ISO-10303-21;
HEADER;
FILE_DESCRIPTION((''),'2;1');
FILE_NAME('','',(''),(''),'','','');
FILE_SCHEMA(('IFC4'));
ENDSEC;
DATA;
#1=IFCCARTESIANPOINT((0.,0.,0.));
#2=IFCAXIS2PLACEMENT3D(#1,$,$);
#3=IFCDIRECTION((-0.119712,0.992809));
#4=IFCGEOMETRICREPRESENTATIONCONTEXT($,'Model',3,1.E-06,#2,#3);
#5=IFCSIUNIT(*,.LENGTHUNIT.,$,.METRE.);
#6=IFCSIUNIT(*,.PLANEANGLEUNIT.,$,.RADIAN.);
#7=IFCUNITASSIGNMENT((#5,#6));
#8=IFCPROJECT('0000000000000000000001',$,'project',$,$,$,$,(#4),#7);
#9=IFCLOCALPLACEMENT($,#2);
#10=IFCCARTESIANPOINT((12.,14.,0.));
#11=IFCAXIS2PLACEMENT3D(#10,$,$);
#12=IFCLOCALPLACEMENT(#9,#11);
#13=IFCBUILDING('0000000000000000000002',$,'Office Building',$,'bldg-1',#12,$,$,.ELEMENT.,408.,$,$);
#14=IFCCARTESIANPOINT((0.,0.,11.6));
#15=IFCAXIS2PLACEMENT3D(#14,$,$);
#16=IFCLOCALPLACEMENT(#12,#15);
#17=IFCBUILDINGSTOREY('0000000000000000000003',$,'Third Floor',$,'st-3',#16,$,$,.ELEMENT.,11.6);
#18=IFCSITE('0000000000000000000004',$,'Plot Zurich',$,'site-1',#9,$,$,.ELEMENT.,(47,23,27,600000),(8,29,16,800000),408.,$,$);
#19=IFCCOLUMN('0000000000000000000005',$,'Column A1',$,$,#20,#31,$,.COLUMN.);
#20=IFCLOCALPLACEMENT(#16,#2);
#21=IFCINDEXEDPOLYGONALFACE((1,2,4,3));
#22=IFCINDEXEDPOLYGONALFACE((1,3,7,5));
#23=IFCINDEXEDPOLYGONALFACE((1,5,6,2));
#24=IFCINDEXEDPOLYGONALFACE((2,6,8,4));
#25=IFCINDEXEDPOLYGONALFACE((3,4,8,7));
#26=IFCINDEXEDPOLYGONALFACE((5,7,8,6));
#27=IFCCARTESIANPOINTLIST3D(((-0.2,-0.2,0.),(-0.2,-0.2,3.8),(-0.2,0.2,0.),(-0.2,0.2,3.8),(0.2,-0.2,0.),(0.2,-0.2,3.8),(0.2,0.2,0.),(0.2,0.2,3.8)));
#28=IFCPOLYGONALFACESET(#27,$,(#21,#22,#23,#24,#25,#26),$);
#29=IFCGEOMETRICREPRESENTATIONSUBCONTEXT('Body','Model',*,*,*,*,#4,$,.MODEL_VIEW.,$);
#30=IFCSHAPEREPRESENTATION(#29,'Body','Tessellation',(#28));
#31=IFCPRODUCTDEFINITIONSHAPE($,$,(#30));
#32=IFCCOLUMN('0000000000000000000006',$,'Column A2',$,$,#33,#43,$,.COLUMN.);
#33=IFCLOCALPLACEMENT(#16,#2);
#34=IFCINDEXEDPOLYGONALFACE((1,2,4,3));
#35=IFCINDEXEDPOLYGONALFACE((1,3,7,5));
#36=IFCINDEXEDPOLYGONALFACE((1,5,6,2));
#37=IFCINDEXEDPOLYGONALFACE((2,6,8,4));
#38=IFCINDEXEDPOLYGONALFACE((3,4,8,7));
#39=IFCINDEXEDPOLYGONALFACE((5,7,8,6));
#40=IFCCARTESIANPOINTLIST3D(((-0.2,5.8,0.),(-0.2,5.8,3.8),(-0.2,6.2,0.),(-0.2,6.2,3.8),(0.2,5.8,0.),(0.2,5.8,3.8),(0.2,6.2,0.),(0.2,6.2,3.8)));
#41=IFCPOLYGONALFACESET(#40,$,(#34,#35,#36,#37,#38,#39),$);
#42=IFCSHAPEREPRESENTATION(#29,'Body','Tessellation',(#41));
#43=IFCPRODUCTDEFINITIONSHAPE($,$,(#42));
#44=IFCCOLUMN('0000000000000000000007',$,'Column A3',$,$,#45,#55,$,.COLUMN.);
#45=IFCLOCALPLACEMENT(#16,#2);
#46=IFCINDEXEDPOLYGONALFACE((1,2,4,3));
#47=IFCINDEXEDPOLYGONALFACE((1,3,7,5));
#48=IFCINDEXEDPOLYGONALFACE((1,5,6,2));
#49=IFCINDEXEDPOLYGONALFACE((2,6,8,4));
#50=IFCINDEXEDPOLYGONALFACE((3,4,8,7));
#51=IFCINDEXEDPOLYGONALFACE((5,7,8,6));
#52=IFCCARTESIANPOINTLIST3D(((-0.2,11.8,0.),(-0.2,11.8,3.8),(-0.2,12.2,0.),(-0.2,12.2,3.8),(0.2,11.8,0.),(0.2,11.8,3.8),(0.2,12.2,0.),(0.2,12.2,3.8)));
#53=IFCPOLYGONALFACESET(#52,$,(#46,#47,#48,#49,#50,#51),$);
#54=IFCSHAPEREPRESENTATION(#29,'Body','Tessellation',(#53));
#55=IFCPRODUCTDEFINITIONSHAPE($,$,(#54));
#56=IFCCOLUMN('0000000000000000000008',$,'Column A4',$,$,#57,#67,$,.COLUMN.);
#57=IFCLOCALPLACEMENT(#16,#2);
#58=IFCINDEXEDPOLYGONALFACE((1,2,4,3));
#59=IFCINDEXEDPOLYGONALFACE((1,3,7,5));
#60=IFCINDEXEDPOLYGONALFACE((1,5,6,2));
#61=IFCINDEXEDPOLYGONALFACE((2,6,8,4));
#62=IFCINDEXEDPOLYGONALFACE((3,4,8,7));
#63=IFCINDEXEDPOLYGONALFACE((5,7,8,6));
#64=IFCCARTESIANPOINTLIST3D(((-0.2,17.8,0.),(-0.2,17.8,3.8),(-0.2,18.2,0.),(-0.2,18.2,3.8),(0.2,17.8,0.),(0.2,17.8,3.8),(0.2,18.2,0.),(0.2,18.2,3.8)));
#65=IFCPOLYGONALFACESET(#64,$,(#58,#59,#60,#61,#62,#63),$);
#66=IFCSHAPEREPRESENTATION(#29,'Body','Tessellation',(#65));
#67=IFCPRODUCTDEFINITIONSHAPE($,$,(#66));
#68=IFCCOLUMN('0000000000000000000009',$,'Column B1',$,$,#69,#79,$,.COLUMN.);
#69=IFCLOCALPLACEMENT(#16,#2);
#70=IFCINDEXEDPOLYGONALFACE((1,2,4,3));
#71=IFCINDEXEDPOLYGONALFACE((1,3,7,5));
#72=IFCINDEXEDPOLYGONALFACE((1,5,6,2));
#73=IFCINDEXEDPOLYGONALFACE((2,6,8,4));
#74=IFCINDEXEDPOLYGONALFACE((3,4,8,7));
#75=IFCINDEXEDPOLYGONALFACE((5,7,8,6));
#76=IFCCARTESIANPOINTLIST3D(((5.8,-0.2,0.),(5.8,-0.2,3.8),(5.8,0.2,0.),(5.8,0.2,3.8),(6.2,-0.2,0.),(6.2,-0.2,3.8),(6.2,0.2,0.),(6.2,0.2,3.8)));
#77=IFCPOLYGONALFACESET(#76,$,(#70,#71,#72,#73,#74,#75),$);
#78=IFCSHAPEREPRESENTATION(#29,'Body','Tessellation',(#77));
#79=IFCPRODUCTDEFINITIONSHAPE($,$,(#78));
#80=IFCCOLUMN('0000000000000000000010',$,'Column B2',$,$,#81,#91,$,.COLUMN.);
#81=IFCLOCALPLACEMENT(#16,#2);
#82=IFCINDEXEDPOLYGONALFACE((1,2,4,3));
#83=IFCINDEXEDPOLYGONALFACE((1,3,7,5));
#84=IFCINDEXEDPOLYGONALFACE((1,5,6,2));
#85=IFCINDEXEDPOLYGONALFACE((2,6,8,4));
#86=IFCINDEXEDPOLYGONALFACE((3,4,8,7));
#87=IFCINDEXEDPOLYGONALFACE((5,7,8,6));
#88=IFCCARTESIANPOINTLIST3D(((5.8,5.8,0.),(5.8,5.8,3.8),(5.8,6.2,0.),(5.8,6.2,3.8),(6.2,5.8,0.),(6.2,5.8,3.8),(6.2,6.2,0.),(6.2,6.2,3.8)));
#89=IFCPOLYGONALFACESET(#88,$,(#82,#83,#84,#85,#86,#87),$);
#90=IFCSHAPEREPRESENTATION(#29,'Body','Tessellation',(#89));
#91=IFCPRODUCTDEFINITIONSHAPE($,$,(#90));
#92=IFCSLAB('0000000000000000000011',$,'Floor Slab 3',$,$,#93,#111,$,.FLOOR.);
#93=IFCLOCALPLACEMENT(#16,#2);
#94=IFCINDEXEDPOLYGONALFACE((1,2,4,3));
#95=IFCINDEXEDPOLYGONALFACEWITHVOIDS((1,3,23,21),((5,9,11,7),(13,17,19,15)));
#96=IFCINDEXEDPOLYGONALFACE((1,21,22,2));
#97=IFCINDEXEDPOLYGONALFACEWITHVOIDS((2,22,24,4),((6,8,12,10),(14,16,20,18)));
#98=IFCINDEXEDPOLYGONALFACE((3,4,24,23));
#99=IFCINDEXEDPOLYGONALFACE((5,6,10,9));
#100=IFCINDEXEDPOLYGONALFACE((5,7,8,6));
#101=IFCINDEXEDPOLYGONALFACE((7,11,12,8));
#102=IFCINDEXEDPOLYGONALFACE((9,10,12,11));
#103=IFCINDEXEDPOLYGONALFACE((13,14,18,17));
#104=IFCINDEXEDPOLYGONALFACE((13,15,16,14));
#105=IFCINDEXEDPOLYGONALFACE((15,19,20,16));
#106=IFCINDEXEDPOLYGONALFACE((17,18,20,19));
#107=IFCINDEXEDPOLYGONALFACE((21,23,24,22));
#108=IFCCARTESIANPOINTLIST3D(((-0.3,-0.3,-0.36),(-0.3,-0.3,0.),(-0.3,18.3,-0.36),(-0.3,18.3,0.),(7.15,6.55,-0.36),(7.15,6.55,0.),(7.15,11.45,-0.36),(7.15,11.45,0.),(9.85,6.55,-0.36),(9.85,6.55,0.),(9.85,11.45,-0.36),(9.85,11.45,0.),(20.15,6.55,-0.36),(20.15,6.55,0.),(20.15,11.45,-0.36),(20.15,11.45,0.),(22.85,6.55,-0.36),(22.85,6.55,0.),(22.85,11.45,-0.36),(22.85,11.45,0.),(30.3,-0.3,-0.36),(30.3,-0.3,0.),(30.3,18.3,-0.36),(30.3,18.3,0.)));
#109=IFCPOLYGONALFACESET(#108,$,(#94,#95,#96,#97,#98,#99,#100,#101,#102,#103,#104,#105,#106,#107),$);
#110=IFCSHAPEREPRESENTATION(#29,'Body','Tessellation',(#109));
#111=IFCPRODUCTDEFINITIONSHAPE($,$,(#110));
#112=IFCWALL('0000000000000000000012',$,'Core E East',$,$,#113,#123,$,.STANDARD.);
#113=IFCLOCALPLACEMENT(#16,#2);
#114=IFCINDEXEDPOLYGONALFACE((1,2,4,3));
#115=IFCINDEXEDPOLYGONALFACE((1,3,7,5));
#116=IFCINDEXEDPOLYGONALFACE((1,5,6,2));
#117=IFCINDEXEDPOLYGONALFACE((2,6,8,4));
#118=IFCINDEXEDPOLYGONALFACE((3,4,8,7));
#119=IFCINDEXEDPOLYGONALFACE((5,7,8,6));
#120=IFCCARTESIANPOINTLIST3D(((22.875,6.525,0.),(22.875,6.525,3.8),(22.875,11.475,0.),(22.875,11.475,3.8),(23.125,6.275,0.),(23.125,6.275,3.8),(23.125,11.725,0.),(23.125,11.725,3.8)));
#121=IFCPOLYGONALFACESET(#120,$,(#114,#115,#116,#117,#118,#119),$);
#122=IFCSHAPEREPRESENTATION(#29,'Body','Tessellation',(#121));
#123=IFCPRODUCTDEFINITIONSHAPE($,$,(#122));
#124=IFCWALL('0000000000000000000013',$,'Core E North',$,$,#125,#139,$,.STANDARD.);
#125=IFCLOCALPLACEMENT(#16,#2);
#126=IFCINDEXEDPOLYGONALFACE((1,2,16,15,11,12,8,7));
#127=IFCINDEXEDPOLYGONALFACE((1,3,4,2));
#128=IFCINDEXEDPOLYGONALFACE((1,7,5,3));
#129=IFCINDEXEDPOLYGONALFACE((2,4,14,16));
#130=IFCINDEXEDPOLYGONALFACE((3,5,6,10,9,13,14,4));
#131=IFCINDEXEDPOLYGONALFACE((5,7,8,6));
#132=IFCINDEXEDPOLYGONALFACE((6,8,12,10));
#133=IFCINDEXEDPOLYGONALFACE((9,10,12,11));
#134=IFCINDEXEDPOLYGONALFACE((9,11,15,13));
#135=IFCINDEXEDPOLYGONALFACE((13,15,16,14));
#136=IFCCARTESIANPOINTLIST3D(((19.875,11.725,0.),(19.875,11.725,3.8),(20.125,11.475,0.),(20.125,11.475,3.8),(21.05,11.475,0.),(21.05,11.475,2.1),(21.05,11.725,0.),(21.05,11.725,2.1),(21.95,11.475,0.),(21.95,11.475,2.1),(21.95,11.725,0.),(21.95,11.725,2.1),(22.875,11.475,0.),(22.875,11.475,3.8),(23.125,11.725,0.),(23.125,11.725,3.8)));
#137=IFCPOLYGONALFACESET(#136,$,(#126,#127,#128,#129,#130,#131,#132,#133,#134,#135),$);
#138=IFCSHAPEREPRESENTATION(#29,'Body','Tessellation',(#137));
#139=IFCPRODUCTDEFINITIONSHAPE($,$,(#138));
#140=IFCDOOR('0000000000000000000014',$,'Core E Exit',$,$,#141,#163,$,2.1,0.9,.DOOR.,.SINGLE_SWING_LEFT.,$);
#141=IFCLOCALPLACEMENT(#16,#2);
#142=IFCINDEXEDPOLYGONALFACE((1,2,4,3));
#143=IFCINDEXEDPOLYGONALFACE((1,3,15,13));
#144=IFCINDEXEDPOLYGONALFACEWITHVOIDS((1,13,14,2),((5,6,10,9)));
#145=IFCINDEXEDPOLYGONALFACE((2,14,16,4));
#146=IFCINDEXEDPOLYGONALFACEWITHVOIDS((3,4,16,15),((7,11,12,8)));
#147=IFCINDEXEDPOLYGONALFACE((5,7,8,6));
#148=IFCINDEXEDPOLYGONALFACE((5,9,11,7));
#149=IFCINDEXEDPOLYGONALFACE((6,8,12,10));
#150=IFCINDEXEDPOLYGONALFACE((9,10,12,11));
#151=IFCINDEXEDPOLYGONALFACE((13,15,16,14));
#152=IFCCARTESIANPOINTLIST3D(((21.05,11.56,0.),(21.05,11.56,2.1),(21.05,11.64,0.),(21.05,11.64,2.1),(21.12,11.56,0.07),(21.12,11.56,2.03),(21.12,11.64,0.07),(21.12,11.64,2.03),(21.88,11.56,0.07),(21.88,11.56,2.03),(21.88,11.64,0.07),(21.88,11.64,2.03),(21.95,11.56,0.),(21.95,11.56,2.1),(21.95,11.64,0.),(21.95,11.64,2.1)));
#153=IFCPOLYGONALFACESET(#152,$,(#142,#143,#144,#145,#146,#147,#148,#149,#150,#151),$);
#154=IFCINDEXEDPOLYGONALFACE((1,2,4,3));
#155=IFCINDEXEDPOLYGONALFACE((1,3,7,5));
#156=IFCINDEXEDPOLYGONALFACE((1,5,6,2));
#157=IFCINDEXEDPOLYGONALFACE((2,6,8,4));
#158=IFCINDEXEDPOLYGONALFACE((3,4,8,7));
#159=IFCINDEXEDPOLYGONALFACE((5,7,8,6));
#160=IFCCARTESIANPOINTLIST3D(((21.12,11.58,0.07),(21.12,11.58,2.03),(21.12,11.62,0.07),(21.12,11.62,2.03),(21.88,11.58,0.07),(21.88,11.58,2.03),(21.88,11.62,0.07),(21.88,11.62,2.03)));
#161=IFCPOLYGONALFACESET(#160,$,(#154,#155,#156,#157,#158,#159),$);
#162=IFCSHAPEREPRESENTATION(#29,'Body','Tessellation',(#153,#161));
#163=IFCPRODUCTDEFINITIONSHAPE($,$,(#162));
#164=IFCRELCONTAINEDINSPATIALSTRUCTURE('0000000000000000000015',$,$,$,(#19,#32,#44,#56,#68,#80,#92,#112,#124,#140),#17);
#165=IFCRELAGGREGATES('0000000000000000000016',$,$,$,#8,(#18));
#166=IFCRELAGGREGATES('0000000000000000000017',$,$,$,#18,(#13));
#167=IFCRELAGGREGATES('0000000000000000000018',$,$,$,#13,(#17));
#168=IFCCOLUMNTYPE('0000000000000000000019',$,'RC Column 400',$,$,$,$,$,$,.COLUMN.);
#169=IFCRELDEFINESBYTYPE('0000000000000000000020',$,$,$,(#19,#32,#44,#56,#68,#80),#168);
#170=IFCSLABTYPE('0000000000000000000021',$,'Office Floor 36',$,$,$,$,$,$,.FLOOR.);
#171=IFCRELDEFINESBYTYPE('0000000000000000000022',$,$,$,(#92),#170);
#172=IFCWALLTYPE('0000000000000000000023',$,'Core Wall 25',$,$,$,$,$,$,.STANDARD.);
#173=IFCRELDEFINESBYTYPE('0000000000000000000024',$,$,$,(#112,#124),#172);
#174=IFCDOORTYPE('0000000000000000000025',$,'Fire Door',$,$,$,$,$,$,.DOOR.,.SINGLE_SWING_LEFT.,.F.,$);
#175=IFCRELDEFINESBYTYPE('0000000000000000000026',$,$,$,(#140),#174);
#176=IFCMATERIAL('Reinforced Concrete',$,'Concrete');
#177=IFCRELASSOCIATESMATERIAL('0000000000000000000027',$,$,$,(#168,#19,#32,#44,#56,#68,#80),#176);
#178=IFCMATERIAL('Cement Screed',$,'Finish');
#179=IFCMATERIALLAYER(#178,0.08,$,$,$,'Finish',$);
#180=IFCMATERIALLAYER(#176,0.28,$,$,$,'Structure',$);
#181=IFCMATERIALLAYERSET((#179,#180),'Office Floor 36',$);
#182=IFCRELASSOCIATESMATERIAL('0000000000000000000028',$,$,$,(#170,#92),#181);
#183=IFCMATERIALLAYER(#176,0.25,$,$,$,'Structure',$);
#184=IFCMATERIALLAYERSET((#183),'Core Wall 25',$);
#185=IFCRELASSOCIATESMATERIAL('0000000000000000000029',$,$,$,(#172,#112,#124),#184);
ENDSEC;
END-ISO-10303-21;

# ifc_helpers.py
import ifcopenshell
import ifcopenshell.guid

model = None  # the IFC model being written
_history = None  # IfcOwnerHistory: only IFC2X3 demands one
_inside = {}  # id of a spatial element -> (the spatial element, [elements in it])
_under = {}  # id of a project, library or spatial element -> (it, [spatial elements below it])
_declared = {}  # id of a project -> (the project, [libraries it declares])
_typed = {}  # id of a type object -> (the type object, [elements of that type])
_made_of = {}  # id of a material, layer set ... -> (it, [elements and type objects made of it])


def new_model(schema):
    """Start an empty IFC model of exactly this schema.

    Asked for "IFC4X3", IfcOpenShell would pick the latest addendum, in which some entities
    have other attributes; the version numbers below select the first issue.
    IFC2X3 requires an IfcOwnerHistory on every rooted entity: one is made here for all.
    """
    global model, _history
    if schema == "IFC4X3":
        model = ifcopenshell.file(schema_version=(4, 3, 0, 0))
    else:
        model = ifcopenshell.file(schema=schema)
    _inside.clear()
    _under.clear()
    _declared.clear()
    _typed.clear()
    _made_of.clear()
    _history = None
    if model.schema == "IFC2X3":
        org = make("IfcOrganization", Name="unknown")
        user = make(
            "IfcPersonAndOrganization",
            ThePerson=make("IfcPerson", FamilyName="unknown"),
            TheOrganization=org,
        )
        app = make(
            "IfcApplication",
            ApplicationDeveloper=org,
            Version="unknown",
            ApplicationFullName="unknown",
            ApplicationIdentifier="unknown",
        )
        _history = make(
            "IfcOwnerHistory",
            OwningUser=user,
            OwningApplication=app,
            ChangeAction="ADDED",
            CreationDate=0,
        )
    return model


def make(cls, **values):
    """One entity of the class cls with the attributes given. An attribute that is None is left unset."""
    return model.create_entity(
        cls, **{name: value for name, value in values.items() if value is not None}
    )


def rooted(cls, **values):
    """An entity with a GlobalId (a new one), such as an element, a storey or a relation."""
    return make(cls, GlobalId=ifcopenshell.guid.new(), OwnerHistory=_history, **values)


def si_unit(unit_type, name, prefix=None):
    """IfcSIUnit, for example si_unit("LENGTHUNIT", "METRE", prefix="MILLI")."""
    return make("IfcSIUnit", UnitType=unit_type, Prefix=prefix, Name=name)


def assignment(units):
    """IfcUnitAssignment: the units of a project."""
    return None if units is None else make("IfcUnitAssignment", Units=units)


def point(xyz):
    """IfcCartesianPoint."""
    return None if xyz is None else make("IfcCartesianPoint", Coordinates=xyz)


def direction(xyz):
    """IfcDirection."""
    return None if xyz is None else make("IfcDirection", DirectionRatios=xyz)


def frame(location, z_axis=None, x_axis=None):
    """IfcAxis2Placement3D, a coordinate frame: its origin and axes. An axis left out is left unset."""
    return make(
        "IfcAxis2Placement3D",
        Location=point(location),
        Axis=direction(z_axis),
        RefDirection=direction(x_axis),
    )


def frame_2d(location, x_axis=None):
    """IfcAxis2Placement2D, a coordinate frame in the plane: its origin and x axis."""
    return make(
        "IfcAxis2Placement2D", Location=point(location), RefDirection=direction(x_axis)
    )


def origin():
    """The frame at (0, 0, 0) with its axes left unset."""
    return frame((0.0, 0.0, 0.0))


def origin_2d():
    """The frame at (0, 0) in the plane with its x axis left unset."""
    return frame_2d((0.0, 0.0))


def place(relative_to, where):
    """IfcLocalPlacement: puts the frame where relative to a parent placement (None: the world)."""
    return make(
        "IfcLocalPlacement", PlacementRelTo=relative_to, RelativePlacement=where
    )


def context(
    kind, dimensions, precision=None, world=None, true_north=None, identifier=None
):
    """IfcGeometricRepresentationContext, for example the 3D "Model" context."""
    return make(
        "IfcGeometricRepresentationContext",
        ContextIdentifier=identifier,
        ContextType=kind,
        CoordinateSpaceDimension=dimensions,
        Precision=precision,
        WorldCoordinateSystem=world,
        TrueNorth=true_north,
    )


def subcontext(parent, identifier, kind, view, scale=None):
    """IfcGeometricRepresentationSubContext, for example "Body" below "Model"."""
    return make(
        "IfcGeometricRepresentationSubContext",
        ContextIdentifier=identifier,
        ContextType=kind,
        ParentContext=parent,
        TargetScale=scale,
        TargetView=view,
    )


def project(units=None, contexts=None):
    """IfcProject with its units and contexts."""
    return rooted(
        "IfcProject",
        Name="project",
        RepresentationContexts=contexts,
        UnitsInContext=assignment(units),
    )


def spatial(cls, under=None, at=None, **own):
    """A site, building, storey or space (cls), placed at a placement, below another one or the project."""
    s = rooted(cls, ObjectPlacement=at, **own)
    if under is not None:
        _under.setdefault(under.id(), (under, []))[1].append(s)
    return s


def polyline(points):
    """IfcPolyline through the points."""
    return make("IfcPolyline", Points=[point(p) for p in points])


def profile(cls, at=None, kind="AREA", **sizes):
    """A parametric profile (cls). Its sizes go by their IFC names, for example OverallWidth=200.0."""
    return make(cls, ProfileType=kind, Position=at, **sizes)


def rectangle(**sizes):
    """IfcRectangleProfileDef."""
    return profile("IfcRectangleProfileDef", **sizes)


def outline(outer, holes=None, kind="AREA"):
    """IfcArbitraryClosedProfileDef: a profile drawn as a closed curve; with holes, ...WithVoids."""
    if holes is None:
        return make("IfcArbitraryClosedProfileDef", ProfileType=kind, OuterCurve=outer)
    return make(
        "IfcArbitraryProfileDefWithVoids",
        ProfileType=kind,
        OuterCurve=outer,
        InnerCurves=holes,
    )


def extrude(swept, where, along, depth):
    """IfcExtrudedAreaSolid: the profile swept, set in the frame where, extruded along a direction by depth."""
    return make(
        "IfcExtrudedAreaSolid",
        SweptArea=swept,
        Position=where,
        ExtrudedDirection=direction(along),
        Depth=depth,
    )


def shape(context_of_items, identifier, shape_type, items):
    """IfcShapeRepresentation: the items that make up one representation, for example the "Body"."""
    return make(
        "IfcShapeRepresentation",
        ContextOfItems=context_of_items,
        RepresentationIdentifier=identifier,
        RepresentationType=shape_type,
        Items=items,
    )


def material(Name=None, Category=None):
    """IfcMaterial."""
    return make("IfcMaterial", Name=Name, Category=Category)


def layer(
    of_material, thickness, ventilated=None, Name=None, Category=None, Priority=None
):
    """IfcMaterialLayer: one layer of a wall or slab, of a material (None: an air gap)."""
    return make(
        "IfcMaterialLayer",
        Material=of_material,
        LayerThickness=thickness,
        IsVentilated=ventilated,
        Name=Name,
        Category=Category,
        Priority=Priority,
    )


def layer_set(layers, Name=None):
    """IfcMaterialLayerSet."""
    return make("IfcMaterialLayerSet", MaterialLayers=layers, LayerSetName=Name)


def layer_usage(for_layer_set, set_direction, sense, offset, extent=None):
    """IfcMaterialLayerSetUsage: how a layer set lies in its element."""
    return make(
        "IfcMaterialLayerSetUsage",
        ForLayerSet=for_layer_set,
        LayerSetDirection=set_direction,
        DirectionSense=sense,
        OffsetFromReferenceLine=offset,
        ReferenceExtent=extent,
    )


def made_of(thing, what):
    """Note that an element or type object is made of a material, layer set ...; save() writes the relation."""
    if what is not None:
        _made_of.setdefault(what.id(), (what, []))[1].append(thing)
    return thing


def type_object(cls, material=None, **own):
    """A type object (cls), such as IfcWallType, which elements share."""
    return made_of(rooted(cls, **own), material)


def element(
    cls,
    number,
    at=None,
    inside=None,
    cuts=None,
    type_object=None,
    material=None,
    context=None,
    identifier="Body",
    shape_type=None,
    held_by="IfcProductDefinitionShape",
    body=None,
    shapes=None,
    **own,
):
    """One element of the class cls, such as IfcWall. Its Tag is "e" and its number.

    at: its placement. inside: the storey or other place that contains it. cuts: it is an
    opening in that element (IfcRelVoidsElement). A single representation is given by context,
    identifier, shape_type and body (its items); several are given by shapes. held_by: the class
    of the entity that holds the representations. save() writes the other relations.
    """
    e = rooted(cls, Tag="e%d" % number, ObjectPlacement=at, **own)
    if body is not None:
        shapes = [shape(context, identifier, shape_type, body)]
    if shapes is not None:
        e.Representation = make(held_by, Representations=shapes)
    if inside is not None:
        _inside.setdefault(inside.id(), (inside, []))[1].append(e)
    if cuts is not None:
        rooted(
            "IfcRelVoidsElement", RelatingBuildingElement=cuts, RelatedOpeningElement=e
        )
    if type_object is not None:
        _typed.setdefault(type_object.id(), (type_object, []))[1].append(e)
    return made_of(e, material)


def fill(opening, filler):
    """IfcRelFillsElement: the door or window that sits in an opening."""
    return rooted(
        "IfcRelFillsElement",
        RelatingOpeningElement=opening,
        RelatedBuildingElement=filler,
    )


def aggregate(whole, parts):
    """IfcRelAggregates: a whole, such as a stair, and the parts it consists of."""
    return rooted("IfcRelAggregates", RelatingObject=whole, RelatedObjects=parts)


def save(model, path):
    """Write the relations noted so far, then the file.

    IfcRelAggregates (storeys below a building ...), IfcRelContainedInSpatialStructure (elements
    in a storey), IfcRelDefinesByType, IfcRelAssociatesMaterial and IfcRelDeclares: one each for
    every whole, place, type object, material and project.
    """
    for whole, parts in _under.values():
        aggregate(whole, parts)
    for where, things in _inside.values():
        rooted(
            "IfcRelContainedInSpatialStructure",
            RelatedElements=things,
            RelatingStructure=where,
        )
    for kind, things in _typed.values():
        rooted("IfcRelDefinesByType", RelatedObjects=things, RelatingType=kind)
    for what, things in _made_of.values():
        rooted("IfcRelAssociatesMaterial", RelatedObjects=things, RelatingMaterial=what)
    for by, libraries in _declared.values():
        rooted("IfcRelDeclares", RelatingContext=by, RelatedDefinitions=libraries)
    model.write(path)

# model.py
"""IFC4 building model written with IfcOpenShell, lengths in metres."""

from ifc_helpers import new_model, si_unit, direction, frame, frame_2d, origin, origin_2d, place, context, subcontext, project, spatial, polyline, rectangle, outline, extrude, material, layer, layer_set, layer_usage, type_object, element, fill, save


model = new_model("IFC4")

# Units and contexts
model_context = context("Model", 3, precision=1e-06, world=origin(), true_north=direction((-0.119712, 0.992809)))
body_context = subcontext(model_context, "Body", "Model", "MODEL_VIEW")
ifc_project = project(units=[si_unit("LENGTHUNIT", "METRE"), si_unit("PLANEANGLEUNIT", "RADIAN")], contexts=[model_context])

# Site, building, storey
site_placement = place(None, origin())
site = spatial("IfcSite", under=ifc_project, at=site_placement, Name="Plot Zurich", ObjectType="site-1", CompositionType="ELEMENT", RefLatitude=(47, 23, 27, 600000), RefLongitude=(8, 29, 16, 800000), RefElevation=408.0)
building_placement = place(site_placement, frame((12.0, 14.0, 0.0)))
building = spatial("IfcBuilding", under=site, at=building_placement, Name="Office Building", ObjectType="bldg-1", CompositionType="ELEMENT", ElevationOfRefHeight=408.0)
storey_placement = place(building_placement, frame((0.0, 0.0, 11.6)))
storey = spatial("IfcBuildingStorey", under=building, at=storey_placement, Name="Third Floor", ObjectType="st-3", CompositionType="ELEMENT", Elevation=11.6)

# Columns
ifc_material_1 = material(Name="Reinforced Concrete", Category="Concrete")
column_type = type_object("IfcColumnType", Name="RC Column 400", PredefinedType="COLUMN", material=ifc_material_1)
for number, where, name in (
    (1, (0.0, 0.0, 0.0), "Column A1"),
    (2, (0.0, 6.0, 0.0), "Column A2"),
    (3, (0.0, 12.0, 0.0), "Column A3"),
    (4, (0.0, 18.0, 0.0), "Column A4"),
    (5, (6.0, 0.0, 0.0), "Column B1"),
    (6, (6.0, 6.0, 0.0), "Column B2"),
):
    element("IfcColumn", number, at=place(storey_placement, frame(where)), inside=storey, type_object=column_type, material=ifc_material_1, Name=name, PredefinedType="COLUMN", context=body_context, shape_type="SweptSolid", body=[
        extrude(rectangle(XDim=0.4, YDim=0.4, at=origin_2d()), origin(), (0.0, 0.0, 1.0), 3.8),
    ])

# Slab
ifc_material_2 = material(Name="Cement Screed", Category="Finish")
ifc_layer_1 = layer(ifc_material_2, 0.08, Category="Finish")
ifc_layer_2 = layer(ifc_material_1, 0.28, Category="Structure")
ifc_layer_set_1 = layer_set([ifc_layer_1, ifc_layer_2], Name="Office Floor 36")
ifc_layer_usage_1 = layer_usage(ifc_layer_set_1, "AXIS3", "NEGATIVE", 0.36)
slab_type = type_object("IfcSlabType", Name="Office Floor 36", PredefinedType="FLOOR", material=ifc_layer_set_1)
slab_placement = place(storey_placement, frame((0.0, 0.0, -0.36)))
element("IfcSlab", 7, at=slab_placement, inside=storey, type_object=slab_type, material=ifc_layer_usage_1, Name="Floor Slab 3", PredefinedType="FLOOR", context=body_context, shape_type="SweptSolid", body=[
    extrude(outline(polyline([(-0.3, -0.3), (30.3, -0.3), (30.3, 18.3), (-0.3, 18.3), (-0.3, -0.3)]), holes=[polyline([(7.15, 6.55), (7.15, 11.45), (9.85, 11.45), (9.85, 6.55), (7.15, 6.55)]), polyline([(20.15, 6.55), (20.15, 11.45), (22.85, 11.45), (22.85, 6.55), (20.15, 6.55)])]), origin(), (0.0, 0.0, 1.0), 0.36),
])

# Wall
ifc_layer_3 = layer(ifc_material_1, 0.25, Category="Structure")
ifc_layer_set_2 = layer_set([ifc_layer_3], Name="Core Wall 25")
ifc_layer_usage_2 = layer_usage(ifc_layer_set_2, "AXIS2", "NEGATIVE", 0.125)
wall_type_1 = type_object("IfcWallType", Name="Core Wall 25", PredefinedType="STANDARD", material=ifc_layer_set_2)
wall_1_placement = place(storey_placement, origin())
element("IfcWall", 8, at=wall_1_placement, inside=storey, type_object=wall_type_1, material=ifc_layer_usage_2, Name="Core E East", PredefinedType="STANDARD", context=body_context, shape_type="SweptSolid", body=[
    extrude(outline(polyline([(23.125, 6.275), (23.125, 11.725), (22.875, 11.475), (22.875, 6.525), (23.125, 6.275)])), origin(), (0.0, 0.0, 1.0), 3.8),
])

# Wall, opening, door
ifc_layer_usage_3 = layer_usage(ifc_layer_set_2, "AXIS2", "NEGATIVE", 0.125)
wall_2_placement = place(storey_placement, origin())
wall_2 = element("IfcWall", 9, at=wall_2_placement, inside=storey, type_object=wall_type_1, material=ifc_layer_usage_3, Name="Core E North", PredefinedType="STANDARD", context=body_context, shape_type="SweptSolid", body=[
    extrude(outline(polyline([(23.125, 11.725), (19.875, 11.725), (20.125, 11.475), (22.875, 11.475), (23.125, 11.725)])), origin(), (0.0, 0.0, 1.0), 3.8),
])
opening_1_placement = place(wall_2_placement, frame((21.5, 11.6, 0.0), z_axis=(0.0, 0.0, 1.0), x_axis=(-1.0, 0.0, 0.0)))
opening_1 = element("IfcOpeningElement", 10, at=opening_1_placement, cuts=wall_2, PredefinedType="OPENING", context=body_context, shape_type="SweptSolid", body=[
    extrude(rectangle(XDim=0.9, YDim=0.25, at=origin_2d()), origin(), (0.0, 0.0, 1.0), 2.1),
])
door_type = type_object("IfcDoorType", Name="Fire Door", OperationType="SINGLE_SWING_LEFT", ParameterTakesPrecedence=False, PredefinedType="DOOR")
door_1_placement = place(opening_1_placement, frame((0.0, 0.0, 0.0), z_axis=(0.0, -1.0, 0.0), x_axis=(1.0, 0.0, 0.0)))
door_1 = element("IfcDoor", 11, at=door_1_placement, inside=storey, type_object=door_type, Name="Core E Exit", OperationType="SINGLE_SWING_LEFT", OverallHeight=2.1, OverallWidth=0.9, PredefinedType="DOOR", context=body_context, shape_type="SweptSolid", body=[
    extrude(outline(polyline([(-0.45, 0.0), (0.45, 0.0), (0.45, 2.1), (-0.45, 2.1), (-0.45, 0.0)]), holes=[polyline([(-0.38, 0.07), (0.38, 0.07), (0.38, 2.03), (-0.38, 2.03), (-0.38, 0.07)])]), frame((0.0, 0.0, -0.04)), (0.0, 0.0, 1.0), 0.08),
    extrude(rectangle(XDim=0.76, YDim=1.96, at=frame_2d((0.0, 1.05))), frame((0.0, 0.0, -0.02)), (0.0, 0.0, 1.0), 0.04),
])
fill(opening_1, door_1)

save(model, "model.ifc")
